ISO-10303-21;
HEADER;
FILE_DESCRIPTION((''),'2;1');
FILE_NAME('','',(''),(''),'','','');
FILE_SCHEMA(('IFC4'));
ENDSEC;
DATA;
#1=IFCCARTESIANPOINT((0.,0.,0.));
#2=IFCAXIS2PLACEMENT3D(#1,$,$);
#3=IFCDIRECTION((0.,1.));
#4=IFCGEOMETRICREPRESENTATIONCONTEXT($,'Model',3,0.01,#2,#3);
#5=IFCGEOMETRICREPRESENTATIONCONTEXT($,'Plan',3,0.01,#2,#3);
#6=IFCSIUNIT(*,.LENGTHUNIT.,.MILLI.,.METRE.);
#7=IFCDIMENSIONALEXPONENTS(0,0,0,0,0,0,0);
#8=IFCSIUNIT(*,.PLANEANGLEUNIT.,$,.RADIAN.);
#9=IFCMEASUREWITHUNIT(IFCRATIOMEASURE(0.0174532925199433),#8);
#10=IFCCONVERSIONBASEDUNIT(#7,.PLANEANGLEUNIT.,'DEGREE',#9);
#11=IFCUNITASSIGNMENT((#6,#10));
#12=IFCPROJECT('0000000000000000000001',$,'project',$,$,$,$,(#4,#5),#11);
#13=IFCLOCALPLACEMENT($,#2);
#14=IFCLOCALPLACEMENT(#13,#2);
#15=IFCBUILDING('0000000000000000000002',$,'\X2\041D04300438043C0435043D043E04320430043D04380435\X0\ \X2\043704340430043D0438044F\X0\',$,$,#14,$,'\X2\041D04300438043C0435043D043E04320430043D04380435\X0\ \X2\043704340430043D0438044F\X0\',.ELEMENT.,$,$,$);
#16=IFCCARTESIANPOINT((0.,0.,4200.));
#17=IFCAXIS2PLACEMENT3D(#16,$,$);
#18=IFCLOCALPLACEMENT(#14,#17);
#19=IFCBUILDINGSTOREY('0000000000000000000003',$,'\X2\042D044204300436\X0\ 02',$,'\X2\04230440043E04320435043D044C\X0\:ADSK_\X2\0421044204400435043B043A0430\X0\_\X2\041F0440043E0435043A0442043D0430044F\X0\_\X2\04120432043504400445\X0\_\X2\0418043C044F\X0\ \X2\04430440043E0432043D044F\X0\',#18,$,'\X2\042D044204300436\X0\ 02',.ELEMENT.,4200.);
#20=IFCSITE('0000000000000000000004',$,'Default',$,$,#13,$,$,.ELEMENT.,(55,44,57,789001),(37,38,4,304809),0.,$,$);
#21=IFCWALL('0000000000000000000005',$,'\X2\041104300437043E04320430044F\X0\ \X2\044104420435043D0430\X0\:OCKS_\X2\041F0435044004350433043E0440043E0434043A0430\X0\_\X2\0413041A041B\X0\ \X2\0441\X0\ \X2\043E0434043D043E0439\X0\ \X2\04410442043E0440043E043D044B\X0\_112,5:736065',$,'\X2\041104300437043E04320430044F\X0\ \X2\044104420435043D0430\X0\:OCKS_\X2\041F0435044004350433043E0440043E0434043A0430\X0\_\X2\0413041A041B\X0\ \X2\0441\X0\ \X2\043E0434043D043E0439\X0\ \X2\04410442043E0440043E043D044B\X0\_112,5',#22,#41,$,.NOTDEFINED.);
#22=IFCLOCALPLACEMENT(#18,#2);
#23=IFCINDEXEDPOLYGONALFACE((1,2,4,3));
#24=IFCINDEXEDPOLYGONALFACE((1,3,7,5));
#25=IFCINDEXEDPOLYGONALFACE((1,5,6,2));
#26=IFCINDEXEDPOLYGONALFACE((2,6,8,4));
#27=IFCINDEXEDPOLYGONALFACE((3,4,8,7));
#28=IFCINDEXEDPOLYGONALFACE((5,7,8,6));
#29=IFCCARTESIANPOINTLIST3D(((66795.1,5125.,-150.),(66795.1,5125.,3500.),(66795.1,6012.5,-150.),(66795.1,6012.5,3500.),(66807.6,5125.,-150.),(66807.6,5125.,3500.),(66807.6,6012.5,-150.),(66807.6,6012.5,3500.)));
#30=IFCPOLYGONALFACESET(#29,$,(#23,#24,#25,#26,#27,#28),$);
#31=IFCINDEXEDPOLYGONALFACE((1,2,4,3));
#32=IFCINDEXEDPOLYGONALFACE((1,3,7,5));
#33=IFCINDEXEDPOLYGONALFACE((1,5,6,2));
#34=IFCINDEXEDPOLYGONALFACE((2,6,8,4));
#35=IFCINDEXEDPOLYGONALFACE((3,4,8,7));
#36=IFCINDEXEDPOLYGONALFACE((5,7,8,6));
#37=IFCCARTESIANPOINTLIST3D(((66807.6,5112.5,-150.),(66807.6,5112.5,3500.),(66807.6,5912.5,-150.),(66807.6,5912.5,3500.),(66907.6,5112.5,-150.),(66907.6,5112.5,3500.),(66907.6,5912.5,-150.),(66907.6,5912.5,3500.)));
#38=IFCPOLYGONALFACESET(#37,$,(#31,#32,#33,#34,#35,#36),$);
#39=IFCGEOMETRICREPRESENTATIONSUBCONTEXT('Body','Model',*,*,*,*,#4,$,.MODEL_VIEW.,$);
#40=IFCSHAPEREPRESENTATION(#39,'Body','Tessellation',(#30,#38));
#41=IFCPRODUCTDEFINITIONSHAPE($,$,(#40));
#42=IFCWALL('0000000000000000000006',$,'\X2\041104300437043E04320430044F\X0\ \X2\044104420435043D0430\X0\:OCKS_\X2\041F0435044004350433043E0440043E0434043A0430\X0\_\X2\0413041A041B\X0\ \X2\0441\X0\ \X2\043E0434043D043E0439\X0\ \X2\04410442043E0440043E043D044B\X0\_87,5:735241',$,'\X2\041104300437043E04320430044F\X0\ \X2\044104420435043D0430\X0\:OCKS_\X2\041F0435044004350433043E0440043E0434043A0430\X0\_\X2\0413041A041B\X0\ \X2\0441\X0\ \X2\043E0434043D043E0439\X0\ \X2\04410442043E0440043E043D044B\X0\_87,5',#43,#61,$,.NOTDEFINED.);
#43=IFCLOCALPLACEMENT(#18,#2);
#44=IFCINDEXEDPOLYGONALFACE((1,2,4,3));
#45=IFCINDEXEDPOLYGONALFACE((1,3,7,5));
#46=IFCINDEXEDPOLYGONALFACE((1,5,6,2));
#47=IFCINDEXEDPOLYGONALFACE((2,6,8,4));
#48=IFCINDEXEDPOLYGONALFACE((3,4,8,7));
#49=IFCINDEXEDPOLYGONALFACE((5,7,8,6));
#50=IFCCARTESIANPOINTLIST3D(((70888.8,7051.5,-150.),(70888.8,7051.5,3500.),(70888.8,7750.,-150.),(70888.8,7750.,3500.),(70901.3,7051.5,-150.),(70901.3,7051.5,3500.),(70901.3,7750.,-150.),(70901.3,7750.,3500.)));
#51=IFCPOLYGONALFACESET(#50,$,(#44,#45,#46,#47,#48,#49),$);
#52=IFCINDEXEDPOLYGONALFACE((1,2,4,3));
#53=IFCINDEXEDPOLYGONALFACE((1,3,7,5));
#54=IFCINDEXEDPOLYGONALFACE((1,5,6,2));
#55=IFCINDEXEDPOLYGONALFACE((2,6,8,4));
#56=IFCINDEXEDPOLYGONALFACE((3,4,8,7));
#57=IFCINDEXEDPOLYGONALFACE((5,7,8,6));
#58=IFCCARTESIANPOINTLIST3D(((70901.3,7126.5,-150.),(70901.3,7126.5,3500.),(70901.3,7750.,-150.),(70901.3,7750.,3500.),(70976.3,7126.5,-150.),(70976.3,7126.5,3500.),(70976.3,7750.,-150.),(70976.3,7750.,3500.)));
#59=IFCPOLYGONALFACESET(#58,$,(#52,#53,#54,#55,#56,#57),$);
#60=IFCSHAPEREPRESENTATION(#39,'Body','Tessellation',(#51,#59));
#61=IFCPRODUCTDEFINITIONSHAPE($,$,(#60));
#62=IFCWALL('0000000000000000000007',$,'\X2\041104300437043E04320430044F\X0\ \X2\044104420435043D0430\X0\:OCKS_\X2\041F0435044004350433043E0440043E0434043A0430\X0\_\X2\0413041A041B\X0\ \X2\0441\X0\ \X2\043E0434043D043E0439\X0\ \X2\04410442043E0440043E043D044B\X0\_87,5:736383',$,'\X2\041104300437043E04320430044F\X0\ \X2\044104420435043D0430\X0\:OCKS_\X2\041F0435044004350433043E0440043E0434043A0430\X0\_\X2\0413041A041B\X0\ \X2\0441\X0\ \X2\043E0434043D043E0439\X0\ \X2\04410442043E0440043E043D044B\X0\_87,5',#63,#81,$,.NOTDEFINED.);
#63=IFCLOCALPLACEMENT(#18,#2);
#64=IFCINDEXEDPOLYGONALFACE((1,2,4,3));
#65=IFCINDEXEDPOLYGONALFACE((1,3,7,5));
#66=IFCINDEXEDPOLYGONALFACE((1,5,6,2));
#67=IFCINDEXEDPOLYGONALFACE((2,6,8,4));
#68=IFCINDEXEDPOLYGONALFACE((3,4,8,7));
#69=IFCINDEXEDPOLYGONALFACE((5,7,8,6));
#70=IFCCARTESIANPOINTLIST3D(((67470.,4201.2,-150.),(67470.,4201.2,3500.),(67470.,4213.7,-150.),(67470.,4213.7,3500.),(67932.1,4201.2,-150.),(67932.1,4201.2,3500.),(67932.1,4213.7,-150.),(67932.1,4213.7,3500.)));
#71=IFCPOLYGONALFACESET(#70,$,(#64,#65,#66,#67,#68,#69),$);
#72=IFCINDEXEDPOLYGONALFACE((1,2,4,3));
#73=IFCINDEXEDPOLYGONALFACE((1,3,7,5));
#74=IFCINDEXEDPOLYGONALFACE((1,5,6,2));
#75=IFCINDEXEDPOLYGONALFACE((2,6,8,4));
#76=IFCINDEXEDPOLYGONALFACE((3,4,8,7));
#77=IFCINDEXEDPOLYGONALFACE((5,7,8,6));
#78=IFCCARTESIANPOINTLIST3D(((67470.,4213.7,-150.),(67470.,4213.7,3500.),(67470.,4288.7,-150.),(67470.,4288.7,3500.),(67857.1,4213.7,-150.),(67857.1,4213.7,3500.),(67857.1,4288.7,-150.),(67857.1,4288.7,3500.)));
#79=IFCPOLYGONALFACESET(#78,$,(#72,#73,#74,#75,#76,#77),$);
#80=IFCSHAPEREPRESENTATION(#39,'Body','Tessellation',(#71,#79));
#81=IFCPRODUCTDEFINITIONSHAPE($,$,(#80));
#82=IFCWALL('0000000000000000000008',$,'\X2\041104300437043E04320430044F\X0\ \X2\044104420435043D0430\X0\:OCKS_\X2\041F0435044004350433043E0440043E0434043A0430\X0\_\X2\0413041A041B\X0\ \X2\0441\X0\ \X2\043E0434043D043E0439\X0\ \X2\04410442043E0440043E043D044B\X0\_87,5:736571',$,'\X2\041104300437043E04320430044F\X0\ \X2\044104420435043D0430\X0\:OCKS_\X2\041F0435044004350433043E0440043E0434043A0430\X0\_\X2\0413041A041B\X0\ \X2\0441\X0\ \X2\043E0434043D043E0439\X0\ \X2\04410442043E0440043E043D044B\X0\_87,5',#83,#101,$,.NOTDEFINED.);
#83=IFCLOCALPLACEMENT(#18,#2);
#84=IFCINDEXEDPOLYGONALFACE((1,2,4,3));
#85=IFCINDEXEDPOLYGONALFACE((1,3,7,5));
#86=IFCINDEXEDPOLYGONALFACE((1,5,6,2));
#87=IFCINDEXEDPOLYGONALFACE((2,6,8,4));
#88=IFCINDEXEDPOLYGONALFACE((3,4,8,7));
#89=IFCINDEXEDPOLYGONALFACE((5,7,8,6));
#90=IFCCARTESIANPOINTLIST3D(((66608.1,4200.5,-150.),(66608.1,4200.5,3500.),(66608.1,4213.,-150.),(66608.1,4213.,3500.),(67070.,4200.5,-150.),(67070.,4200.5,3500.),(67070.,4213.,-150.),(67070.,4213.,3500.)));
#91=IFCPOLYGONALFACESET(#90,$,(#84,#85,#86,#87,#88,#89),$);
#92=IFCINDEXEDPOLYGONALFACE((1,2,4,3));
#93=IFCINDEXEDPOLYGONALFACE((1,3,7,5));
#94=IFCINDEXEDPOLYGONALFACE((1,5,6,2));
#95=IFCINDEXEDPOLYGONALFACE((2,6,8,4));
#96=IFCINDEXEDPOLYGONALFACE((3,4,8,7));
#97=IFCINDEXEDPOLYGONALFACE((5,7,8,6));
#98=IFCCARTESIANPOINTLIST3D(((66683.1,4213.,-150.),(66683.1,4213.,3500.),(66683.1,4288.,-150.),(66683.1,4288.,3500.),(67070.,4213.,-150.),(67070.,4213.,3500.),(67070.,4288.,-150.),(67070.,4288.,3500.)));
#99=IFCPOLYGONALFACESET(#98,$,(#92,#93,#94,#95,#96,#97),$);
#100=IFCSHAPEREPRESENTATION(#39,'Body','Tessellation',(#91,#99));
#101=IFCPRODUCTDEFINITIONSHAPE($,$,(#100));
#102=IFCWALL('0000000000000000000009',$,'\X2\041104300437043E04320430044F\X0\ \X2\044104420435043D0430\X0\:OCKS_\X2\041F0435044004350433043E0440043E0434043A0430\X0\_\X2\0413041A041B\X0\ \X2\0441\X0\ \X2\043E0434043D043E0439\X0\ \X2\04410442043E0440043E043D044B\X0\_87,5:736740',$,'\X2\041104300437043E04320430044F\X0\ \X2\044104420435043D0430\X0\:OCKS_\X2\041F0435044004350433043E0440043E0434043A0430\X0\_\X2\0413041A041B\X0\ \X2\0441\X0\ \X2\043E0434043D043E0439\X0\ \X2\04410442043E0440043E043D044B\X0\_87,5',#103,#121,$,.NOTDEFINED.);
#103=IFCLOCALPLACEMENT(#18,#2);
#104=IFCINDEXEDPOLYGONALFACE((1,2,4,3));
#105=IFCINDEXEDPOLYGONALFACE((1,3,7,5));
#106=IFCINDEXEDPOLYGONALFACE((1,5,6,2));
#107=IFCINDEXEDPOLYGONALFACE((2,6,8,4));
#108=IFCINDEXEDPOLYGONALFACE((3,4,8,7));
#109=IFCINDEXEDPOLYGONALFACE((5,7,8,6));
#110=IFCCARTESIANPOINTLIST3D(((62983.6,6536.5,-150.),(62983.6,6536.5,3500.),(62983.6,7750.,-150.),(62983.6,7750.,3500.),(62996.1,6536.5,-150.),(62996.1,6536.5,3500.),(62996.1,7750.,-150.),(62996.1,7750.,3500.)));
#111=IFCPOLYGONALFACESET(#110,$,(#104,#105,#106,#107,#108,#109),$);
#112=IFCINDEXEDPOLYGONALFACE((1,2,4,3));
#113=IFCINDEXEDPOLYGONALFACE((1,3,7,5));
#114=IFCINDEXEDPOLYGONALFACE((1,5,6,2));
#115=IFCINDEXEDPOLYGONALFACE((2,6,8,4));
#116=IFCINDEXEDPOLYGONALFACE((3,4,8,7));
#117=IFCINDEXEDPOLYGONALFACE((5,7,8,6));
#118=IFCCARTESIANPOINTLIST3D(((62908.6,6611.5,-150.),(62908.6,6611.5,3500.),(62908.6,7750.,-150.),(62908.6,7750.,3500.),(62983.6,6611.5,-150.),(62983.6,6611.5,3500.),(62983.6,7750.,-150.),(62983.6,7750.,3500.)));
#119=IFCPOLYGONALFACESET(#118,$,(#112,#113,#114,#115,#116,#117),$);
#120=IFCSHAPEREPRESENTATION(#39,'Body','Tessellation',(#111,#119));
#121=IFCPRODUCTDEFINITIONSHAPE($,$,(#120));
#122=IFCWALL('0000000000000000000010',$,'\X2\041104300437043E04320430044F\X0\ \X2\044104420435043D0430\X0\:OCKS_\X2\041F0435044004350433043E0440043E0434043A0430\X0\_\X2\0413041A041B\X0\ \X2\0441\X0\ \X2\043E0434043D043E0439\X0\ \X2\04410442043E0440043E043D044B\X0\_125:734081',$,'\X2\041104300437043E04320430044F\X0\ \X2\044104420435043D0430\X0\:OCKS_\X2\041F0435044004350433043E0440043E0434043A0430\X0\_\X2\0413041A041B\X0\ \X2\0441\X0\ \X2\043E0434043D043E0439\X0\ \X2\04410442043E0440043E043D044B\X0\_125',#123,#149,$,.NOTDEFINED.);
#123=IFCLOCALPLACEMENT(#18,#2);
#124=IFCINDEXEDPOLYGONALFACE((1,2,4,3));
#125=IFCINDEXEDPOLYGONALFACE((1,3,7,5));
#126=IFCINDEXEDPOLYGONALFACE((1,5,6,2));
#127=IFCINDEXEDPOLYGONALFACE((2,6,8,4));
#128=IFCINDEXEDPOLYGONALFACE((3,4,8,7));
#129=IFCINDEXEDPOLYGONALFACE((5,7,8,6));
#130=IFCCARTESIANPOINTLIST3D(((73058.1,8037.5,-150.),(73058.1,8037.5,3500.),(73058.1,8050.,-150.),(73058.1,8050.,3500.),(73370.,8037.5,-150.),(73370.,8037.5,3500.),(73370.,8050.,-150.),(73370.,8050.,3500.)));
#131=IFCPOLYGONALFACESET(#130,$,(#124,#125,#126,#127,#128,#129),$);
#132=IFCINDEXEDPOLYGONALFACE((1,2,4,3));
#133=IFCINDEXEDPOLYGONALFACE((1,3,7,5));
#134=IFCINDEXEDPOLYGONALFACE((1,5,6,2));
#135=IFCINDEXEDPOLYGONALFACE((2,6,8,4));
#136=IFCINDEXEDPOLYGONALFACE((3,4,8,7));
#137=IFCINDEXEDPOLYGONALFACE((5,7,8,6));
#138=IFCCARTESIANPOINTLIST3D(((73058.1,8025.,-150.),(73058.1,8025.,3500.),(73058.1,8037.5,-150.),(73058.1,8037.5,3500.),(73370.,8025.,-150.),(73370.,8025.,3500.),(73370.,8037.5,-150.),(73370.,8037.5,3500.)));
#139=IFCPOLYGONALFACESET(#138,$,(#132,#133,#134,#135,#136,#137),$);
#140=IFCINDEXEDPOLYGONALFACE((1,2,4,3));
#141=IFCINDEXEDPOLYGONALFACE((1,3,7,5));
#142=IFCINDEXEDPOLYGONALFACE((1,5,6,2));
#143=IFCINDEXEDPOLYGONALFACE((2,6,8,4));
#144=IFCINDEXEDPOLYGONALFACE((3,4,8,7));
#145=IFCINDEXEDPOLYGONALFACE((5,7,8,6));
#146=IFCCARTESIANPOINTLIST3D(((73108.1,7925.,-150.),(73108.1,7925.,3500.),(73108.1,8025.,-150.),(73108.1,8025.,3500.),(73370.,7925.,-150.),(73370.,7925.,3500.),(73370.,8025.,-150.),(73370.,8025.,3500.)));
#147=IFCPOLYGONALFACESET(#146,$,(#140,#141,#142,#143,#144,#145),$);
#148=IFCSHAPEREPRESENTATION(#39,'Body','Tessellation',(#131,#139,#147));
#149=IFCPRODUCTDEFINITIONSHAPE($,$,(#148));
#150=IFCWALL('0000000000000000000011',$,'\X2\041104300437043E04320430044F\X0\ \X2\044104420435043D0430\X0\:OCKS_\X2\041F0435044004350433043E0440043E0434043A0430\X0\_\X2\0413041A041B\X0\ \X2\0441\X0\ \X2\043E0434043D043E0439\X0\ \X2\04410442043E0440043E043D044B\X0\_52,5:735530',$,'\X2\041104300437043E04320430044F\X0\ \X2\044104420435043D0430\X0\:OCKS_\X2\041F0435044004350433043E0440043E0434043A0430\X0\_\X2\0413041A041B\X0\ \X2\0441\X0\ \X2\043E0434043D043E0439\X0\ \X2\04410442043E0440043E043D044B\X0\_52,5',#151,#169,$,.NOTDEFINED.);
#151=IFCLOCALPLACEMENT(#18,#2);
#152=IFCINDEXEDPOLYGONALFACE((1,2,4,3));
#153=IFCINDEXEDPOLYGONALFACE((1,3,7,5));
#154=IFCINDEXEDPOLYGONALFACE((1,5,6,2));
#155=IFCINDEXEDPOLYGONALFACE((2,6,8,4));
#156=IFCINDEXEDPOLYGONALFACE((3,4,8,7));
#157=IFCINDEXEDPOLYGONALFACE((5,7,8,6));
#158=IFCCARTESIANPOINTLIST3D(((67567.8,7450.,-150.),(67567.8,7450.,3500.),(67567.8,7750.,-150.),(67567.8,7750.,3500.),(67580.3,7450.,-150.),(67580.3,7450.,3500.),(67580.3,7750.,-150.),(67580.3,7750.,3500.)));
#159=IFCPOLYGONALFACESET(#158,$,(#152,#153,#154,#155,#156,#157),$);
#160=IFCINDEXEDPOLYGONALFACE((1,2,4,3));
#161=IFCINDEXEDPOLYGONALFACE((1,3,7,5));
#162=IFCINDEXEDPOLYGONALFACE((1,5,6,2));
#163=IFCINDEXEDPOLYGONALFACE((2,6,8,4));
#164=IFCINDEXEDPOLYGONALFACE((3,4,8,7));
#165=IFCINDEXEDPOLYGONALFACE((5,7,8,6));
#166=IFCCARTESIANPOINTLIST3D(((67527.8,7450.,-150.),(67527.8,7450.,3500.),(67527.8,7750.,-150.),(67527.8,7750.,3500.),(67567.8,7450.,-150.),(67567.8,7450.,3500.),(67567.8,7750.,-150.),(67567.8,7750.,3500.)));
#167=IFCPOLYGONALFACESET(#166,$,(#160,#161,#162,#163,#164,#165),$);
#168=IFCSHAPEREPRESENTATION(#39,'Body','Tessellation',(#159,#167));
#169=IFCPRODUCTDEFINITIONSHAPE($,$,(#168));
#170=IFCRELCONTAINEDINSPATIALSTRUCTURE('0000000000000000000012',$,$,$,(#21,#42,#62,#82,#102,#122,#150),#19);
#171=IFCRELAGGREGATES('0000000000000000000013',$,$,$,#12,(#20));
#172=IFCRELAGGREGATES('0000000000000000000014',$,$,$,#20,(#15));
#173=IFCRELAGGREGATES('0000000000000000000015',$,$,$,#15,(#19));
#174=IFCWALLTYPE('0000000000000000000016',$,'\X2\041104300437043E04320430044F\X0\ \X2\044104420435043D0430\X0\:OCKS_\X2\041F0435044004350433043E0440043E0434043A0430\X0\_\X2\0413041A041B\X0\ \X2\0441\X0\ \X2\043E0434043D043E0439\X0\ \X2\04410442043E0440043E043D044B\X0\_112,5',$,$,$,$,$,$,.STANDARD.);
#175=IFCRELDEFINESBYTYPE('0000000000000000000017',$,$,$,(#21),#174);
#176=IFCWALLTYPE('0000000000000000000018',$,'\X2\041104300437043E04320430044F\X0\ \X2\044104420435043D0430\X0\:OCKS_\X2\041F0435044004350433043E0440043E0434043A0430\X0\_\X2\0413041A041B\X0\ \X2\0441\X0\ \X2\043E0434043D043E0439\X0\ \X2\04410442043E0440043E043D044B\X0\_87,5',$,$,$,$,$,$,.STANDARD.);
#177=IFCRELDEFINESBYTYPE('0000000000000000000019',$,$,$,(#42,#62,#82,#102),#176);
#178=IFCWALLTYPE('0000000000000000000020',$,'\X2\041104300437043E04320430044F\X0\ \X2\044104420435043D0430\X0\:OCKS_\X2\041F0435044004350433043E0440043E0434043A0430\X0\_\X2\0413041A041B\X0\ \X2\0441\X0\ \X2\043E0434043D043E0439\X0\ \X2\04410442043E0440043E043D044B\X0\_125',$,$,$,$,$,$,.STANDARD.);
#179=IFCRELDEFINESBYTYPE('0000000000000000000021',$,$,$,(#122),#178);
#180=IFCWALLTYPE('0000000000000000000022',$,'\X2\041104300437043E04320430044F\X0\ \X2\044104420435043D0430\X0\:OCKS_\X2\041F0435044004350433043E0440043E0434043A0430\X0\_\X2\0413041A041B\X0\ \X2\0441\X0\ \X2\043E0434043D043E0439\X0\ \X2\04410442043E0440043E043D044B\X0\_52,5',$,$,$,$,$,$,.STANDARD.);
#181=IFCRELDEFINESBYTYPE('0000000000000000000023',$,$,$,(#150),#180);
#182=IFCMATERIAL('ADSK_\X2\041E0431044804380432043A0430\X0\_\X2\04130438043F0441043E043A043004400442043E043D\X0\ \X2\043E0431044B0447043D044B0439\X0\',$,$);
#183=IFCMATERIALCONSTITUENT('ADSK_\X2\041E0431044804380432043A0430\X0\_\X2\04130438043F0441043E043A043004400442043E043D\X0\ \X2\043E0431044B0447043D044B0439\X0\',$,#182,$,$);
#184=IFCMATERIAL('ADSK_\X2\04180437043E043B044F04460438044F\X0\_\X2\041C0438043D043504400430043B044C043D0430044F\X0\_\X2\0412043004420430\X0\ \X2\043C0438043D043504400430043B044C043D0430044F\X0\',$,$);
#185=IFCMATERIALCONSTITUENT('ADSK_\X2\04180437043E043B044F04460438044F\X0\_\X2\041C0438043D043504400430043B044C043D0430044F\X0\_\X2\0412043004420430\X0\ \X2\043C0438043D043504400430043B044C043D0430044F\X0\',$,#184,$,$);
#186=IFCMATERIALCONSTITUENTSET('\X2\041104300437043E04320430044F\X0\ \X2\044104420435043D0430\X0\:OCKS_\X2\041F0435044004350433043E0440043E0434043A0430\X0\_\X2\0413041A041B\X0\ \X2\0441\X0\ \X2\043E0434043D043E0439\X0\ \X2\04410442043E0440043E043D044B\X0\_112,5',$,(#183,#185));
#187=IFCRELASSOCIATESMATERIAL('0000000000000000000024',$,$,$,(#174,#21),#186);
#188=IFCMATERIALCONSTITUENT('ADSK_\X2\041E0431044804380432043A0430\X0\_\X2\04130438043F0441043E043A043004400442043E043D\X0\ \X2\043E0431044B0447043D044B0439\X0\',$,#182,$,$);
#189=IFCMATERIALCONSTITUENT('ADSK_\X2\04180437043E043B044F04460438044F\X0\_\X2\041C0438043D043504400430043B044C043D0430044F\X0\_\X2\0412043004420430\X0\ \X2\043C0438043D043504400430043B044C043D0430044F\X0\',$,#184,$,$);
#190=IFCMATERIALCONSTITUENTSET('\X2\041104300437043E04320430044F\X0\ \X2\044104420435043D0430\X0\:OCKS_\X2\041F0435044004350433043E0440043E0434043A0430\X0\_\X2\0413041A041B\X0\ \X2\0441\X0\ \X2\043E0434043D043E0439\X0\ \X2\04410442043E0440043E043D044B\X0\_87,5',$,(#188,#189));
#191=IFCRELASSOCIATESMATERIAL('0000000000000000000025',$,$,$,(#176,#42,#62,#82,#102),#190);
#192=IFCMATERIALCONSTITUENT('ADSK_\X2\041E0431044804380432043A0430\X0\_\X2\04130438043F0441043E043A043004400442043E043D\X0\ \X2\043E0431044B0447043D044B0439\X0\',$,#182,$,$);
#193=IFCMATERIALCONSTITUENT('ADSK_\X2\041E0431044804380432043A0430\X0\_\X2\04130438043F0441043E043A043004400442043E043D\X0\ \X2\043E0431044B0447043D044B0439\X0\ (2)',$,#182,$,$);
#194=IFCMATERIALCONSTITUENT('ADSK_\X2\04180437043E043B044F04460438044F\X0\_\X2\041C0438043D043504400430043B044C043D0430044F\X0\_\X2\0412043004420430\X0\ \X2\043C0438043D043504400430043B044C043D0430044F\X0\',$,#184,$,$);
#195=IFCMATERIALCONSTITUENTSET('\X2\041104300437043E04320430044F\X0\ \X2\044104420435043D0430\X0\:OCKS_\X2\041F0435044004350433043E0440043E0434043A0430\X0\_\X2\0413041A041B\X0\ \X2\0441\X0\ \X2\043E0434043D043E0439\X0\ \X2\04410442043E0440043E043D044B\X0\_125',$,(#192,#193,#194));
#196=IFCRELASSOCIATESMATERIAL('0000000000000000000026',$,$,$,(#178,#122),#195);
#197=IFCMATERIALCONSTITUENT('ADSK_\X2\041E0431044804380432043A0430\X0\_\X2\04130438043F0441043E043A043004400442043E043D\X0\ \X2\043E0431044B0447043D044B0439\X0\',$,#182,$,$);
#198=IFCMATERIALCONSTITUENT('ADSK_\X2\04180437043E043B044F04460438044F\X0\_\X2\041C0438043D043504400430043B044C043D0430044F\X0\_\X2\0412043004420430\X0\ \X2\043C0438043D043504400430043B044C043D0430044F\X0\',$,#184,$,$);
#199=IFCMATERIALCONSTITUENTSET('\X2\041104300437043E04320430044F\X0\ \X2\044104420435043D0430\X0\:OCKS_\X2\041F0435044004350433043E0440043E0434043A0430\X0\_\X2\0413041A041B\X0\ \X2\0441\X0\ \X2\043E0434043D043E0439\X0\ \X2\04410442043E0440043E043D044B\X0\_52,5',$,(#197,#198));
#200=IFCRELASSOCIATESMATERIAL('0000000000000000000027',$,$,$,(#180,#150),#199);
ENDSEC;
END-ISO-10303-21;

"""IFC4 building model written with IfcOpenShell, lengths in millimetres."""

from ifc_helpers import new_model, entity, si_unit, converted_unit, direction, frame, origin, place, context, subcontext, project, spatial, indexed_curve, outline, extrude, material, constituent, constituent_set, type_object, element, save


model = new_model("IFC4")

# Units and contexts
model_context = context("Model", 3, precision=0.01, world=origin(), true_north=direction((0.0, 1.0)))
plan_context = context("Plan", 3, precision=0.01, world=origin(), true_north=direction((0.0, 1.0)))
body_context = subcontext(model_context, "Body", "Model", "MODEL_VIEW")
ifc_project = project(units=[si_unit("LENGTHUNIT", "METRE", prefix="MILLI"), converted_unit("PLANEANGLEUNIT", "DEGREE", entity("IfcRatioMeasure", 0.0174532925199433), si_unit("PLANEANGLEUNIT", "RADIAN"), dimensions=[0, 0, 0, 0, 0, 0, 0])], contexts=[model_context, plan_context])

# Site, building, storey
site_placement = place(None, frame((0.0, 0.0, 0.0)))
site = spatial("IfcSite", under=ifc_project, at=site_placement, Name="Default", CompositionType="ELEMENT", RefLatitude=(55, 44, 57, 789001), RefLongitude=(37, 38, 4, 304809), RefElevation=0.0)
building_placement = place(site_placement, origin())
building = spatial("IfcBuilding", under=site, at=building_placement, Name="Наименование здания", LongName="Наименование здания", CompositionType="ELEMENT")
storey_placement = place(building_placement, frame((0.0, 0.0, 4200.0)))
storey = spatial("IfcBuildingStorey", under=building, at=storey_placement, Name="Этаж 02", ObjectType="Уровень:ADSK_Стрелка_Проектная_Вверх_Имя уровня", LongName="Этаж 02", CompositionType="ELEMENT", Elevation=4200.0)

# Shared definitions
ifc_material_1 = material(Name="ADSK_Обшивка_Гипсокартон обычный")
ifc_material_2 = material(Name="ADSK_Изоляция_Минеральная_Вата минеральная")

# Walls
ifc_constituent_1 = constituent(ifc_material_1, Name="ADSK_Обшивка_Гипсокартон обычный")
ifc_constituent_2 = constituent(ifc_material_2, Name="ADSK_Изоляция_Минеральная_Вата минеральная")
ifc_constituent_set_1 = constituent_set(constituents=[ifc_constituent_1, ifc_constituent_2], Name="Базовая стена:OCKS_Перегородка_ГКЛ с одной стороны_112,5")
wall_type_1 = type_object("IfcWallType", Name="Базовая стена:OCKS_Перегородка_ГКЛ с одной стороны_112,5", PredefinedType="STANDARD", material=ifc_constituent_set_1)
wall_1_placement = place(storey_placement, frame((66851.4, 5125.0, -150.0), z_axis=(0.0, 0.0, 1.0), x_axis=(0.0, 1.0, 0.0)))
element("IfcWall", 1, at=wall_1_placement, inside=storey, type_object=wall_type_1, material=ifc_constituent_set_1, Name="Базовая стена:OCKS_Перегородка_ГКЛ с одной стороны_112,5:736065", ObjectType="Базовая стена:OCKS_Перегородка_ГКЛ с одной стороны_112,5", PredefinedType="NOTDEFINED", context=body_context, shape_type="SweptSolid", body=[
    extrude(outline(indexed_curve([(-6.3, -443.8), (6.2, -443.8), (6.2, 443.8), (-6.3, 443.8), (-6.3, -443.8)], self_intersect=False)), frame((443.8, 50.0, 0.0), z_axis=(0.0, 0.0, 1.0), x_axis=(0.0, -1.0, 0.0)), (0.0, 0.0, 1.0), 3650.0),
    extrude(outline(indexed_curve([(-50.0, -400.0), (50.0, -400.0), (50.0, 400.0), (-50.0, 400.0), (-50.0, -400.0)], self_intersect=False)), frame((387.5, -6.2, 0.0), z_axis=(0.0, 0.0, 1.0), x_axis=(0.0, 1.0, 0.0)), (0.0, 0.0, 1.0), 3650.0),
])
ifc_constituent_3 = constituent(ifc_material_1, Name="ADSK_Обшивка_Гипсокартон обычный")
ifc_constituent_4 = constituent(ifc_material_2, Name="ADSK_Изоляция_Минеральная_Вата минеральная")
ifc_constituent_set_2 = constituent_set(constituents=[ifc_constituent_3, ifc_constituent_4], Name="Базовая стена:OCKS_Перегородка_ГКЛ с одной стороны_87,5")
wall_type_2 = type_object("IfcWallType", Name="Базовая стена:OCKS_Перегородка_ГКЛ с одной стороны_87,5", PredefinedType="STANDARD", material=ifc_constituent_set_2)
wall_2_placement = place(storey_placement, frame((70932.6, 7126.5, -150.0), z_axis=(0.0, 0.0, 1.0), x_axis=(0.0, 1.0, 0.0)))
element("IfcWall", 2, at=wall_2_placement, inside=storey, type_object=wall_type_2, material=ifc_constituent_set_2, Name="Базовая стена:OCKS_Перегородка_ГКЛ с одной стороны_87,5:735241", ObjectType="Базовая стена:OCKS_Перегородка_ГКЛ с одной стороны_87,5", PredefinedType="NOTDEFINED", context=body_context, shape_type="SweptSolid", body=[
    extrude(outline(indexed_curve([(-6.2, -349.3), (6.3, -349.3), (6.2, 349.3), (-6.3, 349.3), (-6.2, -349.3)], self_intersect=False)), frame((274.3, 37.5, 0.0), z_axis=(0.0, 0.0, 1.0), x_axis=(0.0, 1.0, 0.0)), (0.0, 0.0, 1.0), 3650.0),
    extrude(outline(indexed_curve([(-37.5, -311.8), (37.5, -311.8), (37.5, 311.8), (-37.5, 311.8), (-37.5, -311.8)], self_intersect=False)), frame((311.8, -6.3, 0.0), z_axis=(0.0, 0.0, 1.0), x_axis=(0.0, -1.0, 0.0)), (0.0, 0.0, 1.0), 3650.0),
])
wall_3_placement = place(storey_placement, frame((67857.1, 4244.9, -150.0), z_axis=(0.0, 0.0, 1.0), x_axis=(-1.0, 0.0, 0.0)))
element("IfcWall", 3, at=wall_3_placement, inside=storey, type_object=wall_type_2, material=ifc_constituent_set_2, Name="Базовая стена:OCKS_Перегородка_ГКЛ с одной стороны_87,5:736383", ObjectType="Базовая стена:OCKS_Перегородка_ГКЛ с одной стороны_87,5", PredefinedType="NOTDEFINED", context=body_context, shape_type="SweptSolid", body=[
    extrude(outline(indexed_curve([(-6.3, -231.1), (6.2, -231.1), (6.3, 231.1), (-6.2, 231.1), (-6.3, -231.1)], self_intersect=False)), frame((156.1, 37.5, 0.0), z_axis=(0.0, 0.0, 1.0), x_axis=(0.0, -1.0, 0.0)), (0.0, 0.0, 1.0), 3650.0),
    extrude(outline(indexed_curve([(-37.5, -193.6), (37.5, -193.6), (37.5, 193.6), (-37.5, 193.6), (-37.5, -193.6)], self_intersect=False)), frame((193.6, -6.3, 0.0), z_axis=(0.0, 0.0, 1.0), x_axis=(0.0, 1.0, 0.0)), (0.0, 0.0, 1.0), 3650.0),
])
wall_4_placement = place(storey_placement, frame((66683.1, 4244.3, -150.0)))
element("IfcWall", 4, at=wall_4_placement, inside=storey, type_object=wall_type_2, material=ifc_constituent_set_2, Name="Базовая стена:OCKS_Перегородка_ГКЛ с одной стороны_87,5:736571", ObjectType="Базовая стена:OCKS_Перегородка_ГКЛ с одной стороны_87,5", PredefinedType="NOTDEFINED", context=body_context, shape_type="SweptSolid", body=[
    extrude(outline(indexed_curve([(-6.3, -230.9), (6.2, -230.9), (6.3, 230.9), (-6.2, 230.9), (-6.3, -230.9)], self_intersect=False)), frame((155.9, -37.5, 0.0), z_axis=(0.0, 0.0, 1.0), x_axis=(0.0, 1.0, 0.0)), (0.0, 0.0, 1.0), 3650.0),
    extrude(outline(indexed_curve([(-37.5, -193.4), (37.5, -193.4), (37.5, 193.4), (-37.5, 193.4), (-37.5, -193.4)], self_intersect=False)), frame((193.4, 6.2, 0.0), z_axis=(0.0, 0.0, 1.0), x_axis=(0.0, -1.0, 0.0)), (0.0, 0.0, 1.0), 3650.0),
])
wall_5_placement = place(storey_placement, frame((62952.4, 6611.5, -150.0), z_axis=(0.0, 0.0, 1.0), x_axis=(0.0, 1.0, 0.0)))
element("IfcWall", 5, at=wall_5_placement, inside=storey, type_object=wall_type_2, material=ifc_constituent_set_2, Name="Базовая стена:OCKS_Перегородка_ГКЛ с одной стороны_87,5:736740", ObjectType="Базовая стена:OCKS_Перегородка_ГКЛ с одной стороны_87,5", PredefinedType="NOTDEFINED", context=body_context, shape_type="SweptSolid", body=[
    extrude(outline(indexed_curve([(-6.3, -606.7), (6.2, -606.7), (6.2, 606.7), (-6.3, 606.7), (-6.3, -606.7)], self_intersect=False)), frame((531.7, -37.5, 0.0), z_axis=(0.0, 0.0, 1.0), x_axis=(0.0, 1.0, 0.0)), (0.0, 0.0, 1.0), 3650.0),
    extrude(outline(indexed_curve([(-37.5, -569.2), (37.5, -569.2), (37.5, 569.2), (-37.5, 569.2), (-37.5, -569.2)], self_intersect=False)), frame((569.2, 6.3, 0.0), z_axis=(0.0, 0.0, 1.0), x_axis=(0.0, -1.0, 0.0)), (0.0, 0.0, 1.0), 3650.0),
])
ifc_constituent_5 = constituent(ifc_material_1, Name="ADSK_Обшивка_Гипсокартон обычный")
ifc_constituent_6 = constituent(ifc_material_1, Name="ADSK_Обшивка_Гипсокартон обычный (2)")
ifc_constituent_7 = constituent(ifc_material_2, Name="ADSK_Изоляция_Минеральная_Вата минеральная")
ifc_constituent_set_3 = constituent_set(constituents=[ifc_constituent_5, ifc_constituent_6, ifc_constituent_7], Name="Базовая стена:OCKS_Перегородка_ГКЛ с одной стороны_125")
wall_type_3 = type_object("IfcWallType", Name="Базовая стена:OCKS_Перегородка_ГКЛ с одной стороны_125", PredefinedType="STANDARD", material=ifc_constituent_set_3)
wall_6_placement = place(storey_placement, frame((73108.1, 7987.5, -150.0)))
element("IfcWall", 6, at=wall_6_placement, inside=storey, type_object=wall_type_3, material=ifc_constituent_set_3, Name="Базовая стена:OCKS_Перегородка_ГКЛ с одной стороны_125:734081", ObjectType="Базовая стена:OCKS_Перегородка_ГКЛ с одной стороны_125", PredefinedType="NOTDEFINED", context=body_context, shape_type="SweptSolid", body=[
    extrude(outline(indexed_curve([(-6.3, -155.9), (6.2, -155.9), (6.3, 155.9), (-6.2, 155.9), (-6.3, -155.9)], self_intersect=False)), frame((105.9, 56.2, 0.0), z_axis=(0.0, 0.0, 1.0), x_axis=(0.0, -1.0, 0.0)), (0.0, 0.0, 1.0), 3650.0),
    extrude(outline(indexed_curve([(-155.9, -6.2), (155.9, -6.2), (155.9, 6.3), (-155.9, 6.3), (-155.9, -6.2)], self_intersect=False)), frame((105.9, 43.7, 0.0)), (0.0, 0.0, 1.0), 3650.0),
    extrude(outline(indexed_curve([(-50.0, -130.9), (50.0, -130.9), (50.0, 130.9), (-50.0, 130.9), (-50.0, -130.9)], self_intersect=False)), frame((130.9, -12.5, 0.0), z_axis=(0.0, 0.0, 1.0), x_axis=(0.0, 1.0, 0.0)), (0.0, 0.0, 1.0), 3650.0),
])
ifc_constituent_8 = constituent(ifc_material_1, Name="ADSK_Обшивка_Гипсокартон обычный")
ifc_constituent_9 = constituent(ifc_material_2, Name="ADSK_Изоляция_Минеральная_Вата минеральная")
ifc_constituent_set_4 = constituent_set(constituents=[ifc_constituent_8, ifc_constituent_9], Name="Базовая стена:OCKS_Перегородка_ГКЛ с одной стороны_52,5")
wall_type_4 = type_object("IfcWallType", Name="Базовая стена:OCKS_Перегородка_ГКЛ с одной стороны_52,5", PredefinedType="STANDARD", material=ifc_constituent_set_4)
wall_7_placement = place(storey_placement, frame((67554.1, 7450.0, -150.0), z_axis=(0.0, 0.0, 1.0), x_axis=(0.0, 1.0, 0.0)))
element("IfcWall", 7, at=wall_7_placement, inside=storey, type_object=wall_type_4, material=ifc_constituent_set_4, Name="Базовая стена:OCKS_Перегородка_ГКЛ с одной стороны_52,5:735530", ObjectType="Базовая стена:OCKS_Перегородка_ГКЛ с одной стороны_52,5", PredefinedType="NOTDEFINED", context=body_context, shape_type="SweptSolid", body=[
    extrude(outline(indexed_curve([(-6.2, -150.0), (6.3, -150.0), (6.3, 150.0), (-6.2, 150.0), (-6.2, -150.0)], self_intersect=False)), frame((150.0, -20.0, 0.0), z_axis=(0.0, 0.0, 1.0), x_axis=(0.0, 1.0, 0.0)), (0.0, 0.0, 1.0), 3650.0),
    extrude(outline(indexed_curve([(-20.0, -150.0), (20.0, -150.0), (20.0, 150.0), (-20.0, 150.0), (-20.0, -150.0)], self_intersect=False)), frame((150.0, 6.2, 0.0), z_axis=(0.0, 0.0, 1.0), x_axis=(0.0, -1.0, 0.0)), (0.0, 0.0, 1.0), 3650.0),
])

save(model, "model.ifc")
